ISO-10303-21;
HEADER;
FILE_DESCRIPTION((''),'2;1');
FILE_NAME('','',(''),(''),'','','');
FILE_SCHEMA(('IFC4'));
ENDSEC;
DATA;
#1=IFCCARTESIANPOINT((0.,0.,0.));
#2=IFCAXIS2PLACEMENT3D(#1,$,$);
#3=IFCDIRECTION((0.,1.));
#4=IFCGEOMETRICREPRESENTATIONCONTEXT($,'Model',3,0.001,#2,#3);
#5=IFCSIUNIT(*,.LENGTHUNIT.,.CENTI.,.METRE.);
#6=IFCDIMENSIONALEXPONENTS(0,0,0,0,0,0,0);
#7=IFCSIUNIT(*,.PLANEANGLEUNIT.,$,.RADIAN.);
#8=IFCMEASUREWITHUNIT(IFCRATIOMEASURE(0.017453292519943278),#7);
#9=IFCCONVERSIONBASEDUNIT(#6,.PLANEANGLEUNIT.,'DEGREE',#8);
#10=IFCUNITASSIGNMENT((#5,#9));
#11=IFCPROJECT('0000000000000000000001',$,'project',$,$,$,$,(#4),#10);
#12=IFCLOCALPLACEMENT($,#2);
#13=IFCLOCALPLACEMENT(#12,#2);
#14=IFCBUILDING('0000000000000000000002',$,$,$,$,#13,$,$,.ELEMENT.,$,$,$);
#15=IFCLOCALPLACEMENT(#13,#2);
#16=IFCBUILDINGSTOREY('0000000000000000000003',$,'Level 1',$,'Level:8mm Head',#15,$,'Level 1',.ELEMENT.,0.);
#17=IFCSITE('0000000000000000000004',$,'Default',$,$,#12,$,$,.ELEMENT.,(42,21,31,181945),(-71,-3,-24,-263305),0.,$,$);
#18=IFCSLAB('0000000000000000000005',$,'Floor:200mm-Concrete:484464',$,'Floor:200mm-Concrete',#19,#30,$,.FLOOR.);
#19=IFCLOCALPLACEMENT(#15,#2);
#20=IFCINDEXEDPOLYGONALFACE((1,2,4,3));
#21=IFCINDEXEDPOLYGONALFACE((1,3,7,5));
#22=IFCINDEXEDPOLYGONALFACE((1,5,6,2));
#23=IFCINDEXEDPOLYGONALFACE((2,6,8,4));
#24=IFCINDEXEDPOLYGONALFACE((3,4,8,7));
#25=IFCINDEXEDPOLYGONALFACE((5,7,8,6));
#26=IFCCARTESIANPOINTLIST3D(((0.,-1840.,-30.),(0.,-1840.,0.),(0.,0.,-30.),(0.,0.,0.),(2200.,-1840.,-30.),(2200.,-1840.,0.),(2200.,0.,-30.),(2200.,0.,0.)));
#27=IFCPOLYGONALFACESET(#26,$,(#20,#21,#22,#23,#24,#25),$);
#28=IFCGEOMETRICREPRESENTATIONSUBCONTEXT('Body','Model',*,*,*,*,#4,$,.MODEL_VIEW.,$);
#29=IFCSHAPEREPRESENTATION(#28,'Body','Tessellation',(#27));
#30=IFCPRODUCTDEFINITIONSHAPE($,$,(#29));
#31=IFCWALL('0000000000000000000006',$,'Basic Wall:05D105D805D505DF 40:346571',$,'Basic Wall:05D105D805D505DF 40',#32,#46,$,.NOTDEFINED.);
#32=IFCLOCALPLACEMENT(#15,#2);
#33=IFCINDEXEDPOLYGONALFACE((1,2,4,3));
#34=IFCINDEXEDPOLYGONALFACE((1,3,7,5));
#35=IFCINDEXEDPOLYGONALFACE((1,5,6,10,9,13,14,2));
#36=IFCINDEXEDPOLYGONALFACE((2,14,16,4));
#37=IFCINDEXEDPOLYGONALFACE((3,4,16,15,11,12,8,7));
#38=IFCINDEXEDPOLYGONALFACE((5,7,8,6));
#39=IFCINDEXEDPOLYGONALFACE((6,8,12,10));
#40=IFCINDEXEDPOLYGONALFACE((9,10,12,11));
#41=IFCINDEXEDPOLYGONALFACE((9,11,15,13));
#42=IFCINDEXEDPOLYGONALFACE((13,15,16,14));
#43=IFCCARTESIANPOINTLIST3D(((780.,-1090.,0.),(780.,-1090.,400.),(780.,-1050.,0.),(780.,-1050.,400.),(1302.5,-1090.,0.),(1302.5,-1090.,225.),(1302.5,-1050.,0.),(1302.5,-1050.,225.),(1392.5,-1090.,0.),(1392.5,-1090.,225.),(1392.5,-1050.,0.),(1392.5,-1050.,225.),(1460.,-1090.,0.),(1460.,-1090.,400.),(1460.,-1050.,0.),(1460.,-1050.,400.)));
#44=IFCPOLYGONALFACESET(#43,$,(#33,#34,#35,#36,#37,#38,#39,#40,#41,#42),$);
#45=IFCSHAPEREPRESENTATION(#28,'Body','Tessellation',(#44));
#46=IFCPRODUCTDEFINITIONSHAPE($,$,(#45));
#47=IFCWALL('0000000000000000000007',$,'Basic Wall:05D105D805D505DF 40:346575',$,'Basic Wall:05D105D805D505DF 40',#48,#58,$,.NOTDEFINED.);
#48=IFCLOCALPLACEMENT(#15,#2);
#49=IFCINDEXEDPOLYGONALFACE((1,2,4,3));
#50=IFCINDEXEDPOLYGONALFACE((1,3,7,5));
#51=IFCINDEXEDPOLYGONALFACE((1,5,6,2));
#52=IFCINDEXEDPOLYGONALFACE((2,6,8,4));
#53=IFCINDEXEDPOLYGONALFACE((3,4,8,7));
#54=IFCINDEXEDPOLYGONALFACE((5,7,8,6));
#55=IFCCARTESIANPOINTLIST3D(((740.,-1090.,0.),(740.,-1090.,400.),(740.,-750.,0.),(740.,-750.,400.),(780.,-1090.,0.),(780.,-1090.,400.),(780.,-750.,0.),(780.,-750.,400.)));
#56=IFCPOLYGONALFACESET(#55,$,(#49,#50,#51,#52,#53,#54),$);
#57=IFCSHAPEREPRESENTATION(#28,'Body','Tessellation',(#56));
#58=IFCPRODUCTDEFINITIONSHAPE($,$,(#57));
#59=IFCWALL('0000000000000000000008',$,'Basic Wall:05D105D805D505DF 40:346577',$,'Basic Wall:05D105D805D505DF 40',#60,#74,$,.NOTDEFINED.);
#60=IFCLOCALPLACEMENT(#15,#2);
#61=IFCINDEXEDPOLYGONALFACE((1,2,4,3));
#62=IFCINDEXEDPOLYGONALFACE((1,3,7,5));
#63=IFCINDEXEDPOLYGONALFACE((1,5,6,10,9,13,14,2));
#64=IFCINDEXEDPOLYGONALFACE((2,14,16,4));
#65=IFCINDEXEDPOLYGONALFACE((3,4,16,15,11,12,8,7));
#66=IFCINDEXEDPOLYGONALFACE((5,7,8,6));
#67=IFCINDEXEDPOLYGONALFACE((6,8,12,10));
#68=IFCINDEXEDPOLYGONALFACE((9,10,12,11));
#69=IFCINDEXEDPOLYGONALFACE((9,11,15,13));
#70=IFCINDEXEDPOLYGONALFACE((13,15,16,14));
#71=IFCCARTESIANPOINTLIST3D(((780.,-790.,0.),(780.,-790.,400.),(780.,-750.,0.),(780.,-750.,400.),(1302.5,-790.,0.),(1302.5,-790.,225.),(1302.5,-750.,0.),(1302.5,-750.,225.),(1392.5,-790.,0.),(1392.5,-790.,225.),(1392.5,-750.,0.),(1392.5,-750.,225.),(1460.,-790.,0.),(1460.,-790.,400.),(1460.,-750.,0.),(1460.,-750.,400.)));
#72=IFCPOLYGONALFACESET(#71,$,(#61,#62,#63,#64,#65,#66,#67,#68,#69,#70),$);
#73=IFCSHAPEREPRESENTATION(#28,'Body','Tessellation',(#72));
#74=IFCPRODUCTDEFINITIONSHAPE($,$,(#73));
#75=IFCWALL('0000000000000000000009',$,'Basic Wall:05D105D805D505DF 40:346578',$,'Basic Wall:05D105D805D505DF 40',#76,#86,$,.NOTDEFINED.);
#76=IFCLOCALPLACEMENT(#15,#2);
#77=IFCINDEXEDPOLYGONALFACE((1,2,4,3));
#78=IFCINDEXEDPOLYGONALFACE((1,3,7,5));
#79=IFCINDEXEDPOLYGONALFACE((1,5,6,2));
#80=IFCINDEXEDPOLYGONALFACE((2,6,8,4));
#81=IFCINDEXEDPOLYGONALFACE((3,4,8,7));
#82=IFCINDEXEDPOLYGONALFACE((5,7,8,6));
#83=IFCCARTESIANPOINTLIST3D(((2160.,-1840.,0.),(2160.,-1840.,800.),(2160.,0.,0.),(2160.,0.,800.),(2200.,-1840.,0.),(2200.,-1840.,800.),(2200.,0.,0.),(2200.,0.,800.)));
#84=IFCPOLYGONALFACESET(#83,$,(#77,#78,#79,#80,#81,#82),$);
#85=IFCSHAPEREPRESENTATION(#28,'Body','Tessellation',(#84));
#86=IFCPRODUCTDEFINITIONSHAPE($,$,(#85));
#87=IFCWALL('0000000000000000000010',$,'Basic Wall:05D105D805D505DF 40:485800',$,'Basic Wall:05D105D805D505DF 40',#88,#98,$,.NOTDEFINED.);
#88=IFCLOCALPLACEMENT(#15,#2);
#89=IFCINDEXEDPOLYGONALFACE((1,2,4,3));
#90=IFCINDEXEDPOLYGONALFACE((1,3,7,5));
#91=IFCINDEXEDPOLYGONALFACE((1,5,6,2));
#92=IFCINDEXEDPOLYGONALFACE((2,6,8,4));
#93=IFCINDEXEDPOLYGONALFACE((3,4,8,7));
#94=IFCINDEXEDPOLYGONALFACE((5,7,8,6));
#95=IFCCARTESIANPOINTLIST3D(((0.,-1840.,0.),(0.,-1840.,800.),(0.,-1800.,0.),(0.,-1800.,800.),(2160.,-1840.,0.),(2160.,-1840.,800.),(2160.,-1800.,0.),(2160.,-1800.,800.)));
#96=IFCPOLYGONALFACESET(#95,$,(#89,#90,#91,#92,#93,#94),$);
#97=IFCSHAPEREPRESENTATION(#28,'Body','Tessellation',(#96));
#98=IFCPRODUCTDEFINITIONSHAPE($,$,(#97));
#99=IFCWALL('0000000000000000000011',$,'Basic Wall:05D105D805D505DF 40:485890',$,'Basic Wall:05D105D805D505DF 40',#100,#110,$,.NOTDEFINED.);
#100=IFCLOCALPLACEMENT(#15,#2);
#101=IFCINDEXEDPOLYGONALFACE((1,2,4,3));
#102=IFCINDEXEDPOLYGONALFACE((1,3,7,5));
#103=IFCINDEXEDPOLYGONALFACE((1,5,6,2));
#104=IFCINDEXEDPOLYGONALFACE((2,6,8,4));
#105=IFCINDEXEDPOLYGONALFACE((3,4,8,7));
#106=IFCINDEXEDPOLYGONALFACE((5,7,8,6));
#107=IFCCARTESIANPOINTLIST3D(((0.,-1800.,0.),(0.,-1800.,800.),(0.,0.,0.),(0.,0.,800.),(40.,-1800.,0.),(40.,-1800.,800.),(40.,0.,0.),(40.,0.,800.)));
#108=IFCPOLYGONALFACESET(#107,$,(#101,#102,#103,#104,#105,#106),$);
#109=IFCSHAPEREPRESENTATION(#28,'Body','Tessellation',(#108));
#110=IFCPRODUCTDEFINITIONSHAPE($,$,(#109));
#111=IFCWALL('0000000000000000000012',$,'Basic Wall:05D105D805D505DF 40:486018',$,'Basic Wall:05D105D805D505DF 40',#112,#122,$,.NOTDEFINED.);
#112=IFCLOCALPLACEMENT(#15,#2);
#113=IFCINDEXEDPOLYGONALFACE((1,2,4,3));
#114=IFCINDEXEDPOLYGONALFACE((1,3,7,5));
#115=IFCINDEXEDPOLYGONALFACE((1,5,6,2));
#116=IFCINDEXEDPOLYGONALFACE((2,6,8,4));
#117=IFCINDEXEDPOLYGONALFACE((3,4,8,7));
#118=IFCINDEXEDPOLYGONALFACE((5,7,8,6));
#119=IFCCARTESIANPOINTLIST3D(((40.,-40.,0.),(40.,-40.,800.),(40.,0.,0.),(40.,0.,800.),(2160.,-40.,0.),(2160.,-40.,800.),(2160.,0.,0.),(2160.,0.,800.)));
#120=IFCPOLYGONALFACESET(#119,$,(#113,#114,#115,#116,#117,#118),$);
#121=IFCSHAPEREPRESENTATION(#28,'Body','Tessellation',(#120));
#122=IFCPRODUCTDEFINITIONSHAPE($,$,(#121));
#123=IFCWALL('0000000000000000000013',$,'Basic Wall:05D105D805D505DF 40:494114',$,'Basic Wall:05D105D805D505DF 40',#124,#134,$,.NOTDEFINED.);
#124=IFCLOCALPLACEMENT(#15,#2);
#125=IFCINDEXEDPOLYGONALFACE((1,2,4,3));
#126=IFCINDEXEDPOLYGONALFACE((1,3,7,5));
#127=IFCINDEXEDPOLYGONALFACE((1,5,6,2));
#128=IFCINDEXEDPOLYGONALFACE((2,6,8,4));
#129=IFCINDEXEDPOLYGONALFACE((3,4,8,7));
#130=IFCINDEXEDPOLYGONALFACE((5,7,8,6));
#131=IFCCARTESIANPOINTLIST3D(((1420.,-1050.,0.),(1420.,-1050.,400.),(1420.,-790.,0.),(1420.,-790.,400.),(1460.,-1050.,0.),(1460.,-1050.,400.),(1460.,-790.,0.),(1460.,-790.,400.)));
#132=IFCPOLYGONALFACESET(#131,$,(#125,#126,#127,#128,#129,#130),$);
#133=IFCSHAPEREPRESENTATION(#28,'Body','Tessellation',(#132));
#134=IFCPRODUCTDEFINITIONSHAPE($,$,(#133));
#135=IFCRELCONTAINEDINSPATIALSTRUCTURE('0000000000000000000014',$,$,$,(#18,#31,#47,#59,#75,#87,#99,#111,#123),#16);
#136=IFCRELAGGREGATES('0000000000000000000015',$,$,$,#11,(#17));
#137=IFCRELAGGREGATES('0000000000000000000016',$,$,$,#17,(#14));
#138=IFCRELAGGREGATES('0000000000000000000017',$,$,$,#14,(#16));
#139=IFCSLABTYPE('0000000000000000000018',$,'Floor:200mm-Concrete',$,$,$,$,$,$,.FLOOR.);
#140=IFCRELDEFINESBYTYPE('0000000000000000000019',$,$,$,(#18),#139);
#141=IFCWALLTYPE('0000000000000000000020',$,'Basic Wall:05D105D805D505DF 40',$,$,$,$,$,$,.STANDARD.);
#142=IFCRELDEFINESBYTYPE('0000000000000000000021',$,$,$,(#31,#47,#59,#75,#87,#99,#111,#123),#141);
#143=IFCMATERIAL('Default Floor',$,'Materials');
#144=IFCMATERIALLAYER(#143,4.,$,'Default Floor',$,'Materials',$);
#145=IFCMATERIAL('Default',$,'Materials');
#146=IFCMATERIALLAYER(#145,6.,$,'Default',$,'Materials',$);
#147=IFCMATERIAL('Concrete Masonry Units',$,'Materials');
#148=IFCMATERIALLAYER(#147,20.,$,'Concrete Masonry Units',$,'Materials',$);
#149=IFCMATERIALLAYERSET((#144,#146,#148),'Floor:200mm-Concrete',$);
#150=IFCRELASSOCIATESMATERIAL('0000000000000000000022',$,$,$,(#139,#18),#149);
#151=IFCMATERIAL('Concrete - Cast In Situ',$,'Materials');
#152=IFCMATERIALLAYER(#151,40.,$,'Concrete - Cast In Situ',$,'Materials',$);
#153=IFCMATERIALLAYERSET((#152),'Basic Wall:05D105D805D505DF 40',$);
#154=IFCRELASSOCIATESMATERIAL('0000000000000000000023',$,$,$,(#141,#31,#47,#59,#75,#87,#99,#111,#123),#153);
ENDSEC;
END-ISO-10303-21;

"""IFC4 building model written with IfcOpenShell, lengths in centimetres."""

from ifc_helpers import new_model, entity, si_unit, converted_unit, direction, frame, frame_2d, origin, origin_2d_with_axis, place, context, subcontext, project, spatial, rectangle, circle, extrude, material, layer, layer_set, layer_usage, type_object, element, save


model = new_model("IFC4")

# Units and contexts
model_context = context("Model", 3, precision=0.001, world=origin(), true_north=direction((0.0, 1.0)))
body_context = subcontext(model_context, "Body", "Model", "MODEL_VIEW")
ifc_project = project(units=[si_unit("LENGTHUNIT", "METRE", prefix="CENTI"), converted_unit("PLANEANGLEUNIT", "DEGREE", entity("IfcRatioMeasure", 0.017453292519943278), si_unit("PLANEANGLEUNIT", "RADIAN"), dimensions=[0, 0, 0, 0, 0, 0, 0])], contexts=[model_context])

# Site, building, storey
site_placement = place(None, origin())
site = spatial("IfcSite", under=ifc_project, at=site_placement, Name="Default", CompositionType="ELEMENT", RefLatitude=(42, 21, 31, 181945), RefLongitude=(-71, -3, -24, -263305), RefElevation=0.0)
building_placement = place(site_placement, origin())
building = spatial("IfcBuilding", under=site, at=building_placement, CompositionType="ELEMENT")
storey_placement = place(building_placement, origin())
storey = spatial("IfcBuildingStorey", under=building, at=storey_placement, Name="Level 1", ObjectType="Level:8mm Head", LongName="Level 1", CompositionType="ELEMENT", Elevation=0.0)

# Slab
ifc_material_1 = material(Name="Default Floor", Category="Materials")
ifc_layer_1 = layer(ifc_material_1, 4.0, Name="Default Floor", Category="Materials")
ifc_material_2 = material(Name="Default", Category="Materials")
ifc_layer_2 = layer(ifc_material_2, 6.0, Name="Default", Category="Materials")
ifc_material_3 = material(Name="Concrete Masonry Units", Category="Materials")
ifc_layer_3 = layer(ifc_material_3, 20.0, Name="Concrete Masonry Units", Category="Materials")
ifc_layer_set_1 = layer_set([ifc_layer_1, ifc_layer_2, ifc_layer_3], Name="Floor:200mm-Concrete")
ifc_layer_usage_1 = layer_usage(ifc_layer_set_1, "AXIS3", "POSITIVE", 0.0)
slab_type = type_object("IfcSlabType", Name="Floor:200mm-Concrete", PredefinedType="FLOOR", material=ifc_layer_set_1)
slab_placement = place(storey_placement, origin())
element("IfcSlab", 1, at=slab_placement, inside=storey, type_object=slab_type, material=ifc_layer_usage_1, Name="Floor:200mm-Concrete:484464", ObjectType="Floor:200mm-Concrete", PredefinedType="FLOOR", context=body_context, shape_type="SweptSolid", body=[
    extrude(rectangle(XDim=1840.0, YDim=2200.0, at=frame_2d((0.0, 0.0), x_axis=(1.0, 0.0))), frame((1100.0, -920.0, 0.0), z_axis=(0.0, 0.0, -1.0), x_axis=(0.0, 1.0, 0.0)), (0.0, 0.0, 1.0), 30.0),
])

# Wall, openings
ifc_material_4 = material(Name="Concrete - Cast In Situ", Category="Materials")
ifc_layer_4 = layer(ifc_material_4, 40.0, Name="Concrete - Cast In Situ", Category="Materials")
ifc_layer_set_2 = layer_set([ifc_layer_4], Name="Basic Wall:05D105D805D505DF 40")
ifc_layer_usage_2 = layer_usage(ifc_layer_set_2, "AXIS2", "POSITIVE", -20.0)
wall_type_1 = type_object("IfcWallType", Name="Basic Wall:05D105D805D505DF 40", PredefinedType="STANDARD", material=ifc_layer_set_2)
wall_1_placement = place(storey_placement, frame((780.0, -1070.0, 0.0)))
wall_1 = element("IfcWall", 2, at=wall_1_placement, inside=storey, type_object=wall_type_1, material=ifc_layer_usage_2, Name="Basic Wall:05D105D805D505DF 40:346571", ObjectType="Basic Wall:05D105D805D505DF 40", PredefinedType="NOTDEFINED", context=body_context, shape_type="SweptSolid", body=[
    extrude(rectangle(XDim=680.0, YDim=40.0, at=frame_2d((340.0, 0.0), x_axis=(-1.0, 0.0))), origin(), (0.0, 0.0, 1.0), 400.0),
])
opening_1_placement = place(wall_1_placement, origin())
element("IfcOpeningElement", 3, at=opening_1_placement, cuts=wall_1, PredefinedType="OPENING", context=body_context, shape_type="SweptSolid", body=[
    extrude(circle(Radius=4.0, at=origin_2d_with_axis()), frame((567.52, 20.0, 323.98), z_axis=(0.0, -1.0, 0.0), x_axis=(-1.0, 0.0, 0.0)), (0.0, 0.0, 1.0), 40.0),
])
opening_2_placement = place(wall_1_placement, frame((522.5, -20.0, 0.0)))
element("IfcOpeningElement", 4, at=opening_2_placement, cuts=wall_1, PredefinedType="OPENING", context=body_context, shape_type="SweptSolid", body=[
    extrude(rectangle(XDim=225.0, YDim=90.0, at=frame_2d((112.5, 45.0), x_axis=(-1.0, 0.0))), frame((0.0, 0.0, 0.0), z_axis=(0.0, 1.0, 0.0), x_axis=(0.0, 0.0, 1.0)), (0.0, 0.0, 1.0), 40.0),
])
opening_3_placement = place(wall_1_placement, frame((522.5, -20.0, 400.0)))
element("IfcOpeningElement", 5, at=opening_3_placement, cuts=wall_1, PredefinedType="OPENING", context=body_context, shape_type="SweptSolid", body=[
    extrude(rectangle(XDim=225.0, YDim=90.0, at=frame_2d((112.5, 45.0), x_axis=(-1.0, 0.0))), frame((0.0, 0.0, 0.0), z_axis=(0.0, 1.0, 0.0), x_axis=(0.0, 0.0, 1.0)), (0.0, 0.0, 1.0), 40.0),
])

# Wall
ifc_layer_usage_3 = layer_usage(ifc_layer_set_2, "AXIS2", "NEGATIVE", 20.0)
wall_2_placement = place(storey_placement, frame((760.0, -1090.0, 0.0), z_axis=(0.0, 0.0, 1.0), x_axis=(0.0, 1.0, 0.0)))
element("IfcWall", 6, at=wall_2_placement, inside=storey, type_object=wall_type_1, material=ifc_layer_usage_3, Name="Basic Wall:05D105D805D505DF 40:346575", ObjectType="Basic Wall:05D105D805D505DF 40", PredefinedType="NOTDEFINED", context=body_context, shape_type="SweptSolid", body=[
    extrude(rectangle(XDim=340.0, YDim=40.0, at=frame_2d((170.0, 0.0), x_axis=(-1.0, 0.0))), origin(), (0.0, 0.0, 1.0), 400.0),
])

# Wall, openings
ifc_layer_usage_4 = layer_usage(ifc_layer_set_2, "AXIS2", "NEGATIVE", 20.0)
wall_3_placement = place(storey_placement, frame((780.0, -770.0, 0.0)))
wall_3 = element("IfcWall", 7, at=wall_3_placement, inside=storey, type_object=wall_type_1, material=ifc_layer_usage_4, Name="Basic Wall:05D105D805D505DF 40:346577", ObjectType="Basic Wall:05D105D805D505DF 40", PredefinedType="NOTDEFINED", context=body_context, shape_type="SweptSolid", body=[
    extrude(rectangle(XDim=680.0, YDim=40.0, at=frame_2d((340.0, 0.0), x_axis=(-1.0, 0.0))), origin(), (0.0, 0.0, 1.0), 400.0),
])
opening_4_placement = place(wall_3_placement, frame((612.5, 20.0, 0.0)))
element("IfcOpeningElement", 8, at=opening_4_placement, cuts=wall_3, PredefinedType="OPENING", context=body_context, shape_type="SweptSolid", body=[
    extrude(rectangle(XDim=225.0, YDim=90.0, at=frame_2d((112.5, 45.0), x_axis=(-1.0, 0.0))), frame((0.0, 0.0, 0.0), z_axis=(0.0, -1.0, 0.0), x_axis=(0.0, 0.0, 1.0)), (0.0, 0.0, 1.0), 40.0),
])
opening_5_placement = place(wall_3_placement, frame((612.5, 20.0, 400.0)))
element("IfcOpeningElement", 9, at=opening_5_placement, cuts=wall_3, PredefinedType="OPENING", context=body_context, shape_type="SweptSolid", body=[
    extrude(rectangle(XDim=225.0, YDim=90.0, at=frame_2d((112.5, 45.0), x_axis=(-1.0, 0.0))), frame((0.0, 0.0, 0.0), z_axis=(0.0, -1.0, 0.0), x_axis=(0.0, 0.0, 1.0)), (0.0, 0.0, 1.0), 40.0),
])

# Walls
ifc_layer_usage_5 = layer_usage(ifc_layer_set_2, "AXIS2", "POSITIVE", -20.0)
wall_4_placement = place(storey_placement, frame((2180.0, 0.0, 0.0), z_axis=(0.0, 0.0, 1.0), x_axis=(0.0, -1.0, 0.0)))
element("IfcWall", 10, at=wall_4_placement, inside=storey, type_object=wall_type_1, material=ifc_layer_usage_5, Name="Basic Wall:05D105D805D505DF 40:346578", ObjectType="Basic Wall:05D105D805D505DF 40", PredefinedType="NOTDEFINED", context=body_context, shape_type="SweptSolid", body=[
    extrude(rectangle(XDim=1840.0, YDim=40.0, at=frame_2d((920.0, 0.0), x_axis=(-1.0, 0.0))), origin(), (0.0, 0.0, 1.0), 800.0),
])
ifc_layer_usage_6 = layer_usage(ifc_layer_set_2, "AXIS2", "NEGATIVE", 20.0)
wall_5_placement = place(storey_placement, frame((2160.0, -1820.0, 0.0), z_axis=(0.0, 0.0, 1.0), x_axis=(-1.0, 0.0, 0.0)))
element("IfcWall", 11, at=wall_5_placement, inside=storey, type_object=wall_type_1, material=ifc_layer_usage_6, Name="Basic Wall:05D105D805D505DF 40:485800", ObjectType="Basic Wall:05D105D805D505DF 40", PredefinedType="NOTDEFINED", context=body_context, shape_type="SweptSolid", body=[
    extrude(rectangle(XDim=2160.0, YDim=40.0, at=frame_2d((1080.0, 0.0), x_axis=(-1.0, 0.0))), origin(), (0.0, 0.0, 1.0), 800.0),
])
ifc_layer_usage_7 = layer_usage(ifc_layer_set_2, "AXIS2", "NEGATIVE", 20.0)
wall_6_placement = place(storey_placement, frame((20.0, -1800.0, 0.0), z_axis=(0.0, 0.0, 1.0), x_axis=(0.0, 1.0, 0.0)))
element("IfcWall", 12, at=wall_6_placement, inside=storey, type_object=wall_type_1, material=ifc_layer_usage_7, Name="Basic Wall:05D105D805D505DF 40:485890", ObjectType="Basic Wall:05D105D805D505DF 40", PredefinedType="NOTDEFINED", context=body_context, shape_type="SweptSolid", body=[
    extrude(rectangle(XDim=1800.0, YDim=40.0, at=frame_2d((900.0, 0.0), x_axis=(-1.0, 0.0))), origin(), (0.0, 0.0, 1.0), 800.0),
])
ifc_layer_usage_8 = layer_usage(ifc_layer_set_2, "AXIS2", "NEGATIVE", 20.0)
wall_7_placement = place(storey_placement, frame((40.0, -20.0, 0.0)))
element("IfcWall", 13, at=wall_7_placement, inside=storey, type_object=wall_type_1, material=ifc_layer_usage_8, Name="Basic Wall:05D105D805D505DF 40:486018", ObjectType="Basic Wall:05D105D805D505DF 40", PredefinedType="NOTDEFINED", context=body_context, shape_type="SweptSolid", body=[
    extrude(rectangle(XDim=2120.0, YDim=40.0, at=frame_2d((1060.0, 0.0), x_axis=(-1.0, 0.0))), origin(), (0.0, 0.0, 1.0), 800.0),
])
ifc_layer_usage_9 = layer_usage(ifc_layer_set_2, "AXIS2", "NEGATIVE", 20.0)
wall_8_placement = place(storey_placement, frame((1440.0, -1050.0, 0.0), z_axis=(0.0, 0.0, 1.0), x_axis=(0.0, 1.0, 0.0)))
element("IfcWall", 14, at=wall_8_placement, inside=storey, type_object=wall_type_1, material=ifc_layer_usage_9, Name="Basic Wall:05D105D805D505DF 40:494114", ObjectType="Basic Wall:05D105D805D505DF 40", PredefinedType="NOTDEFINED", context=body_context, shape_type="SweptSolid", body=[
    extrude(rectangle(XDim=260.0, YDim=40.0, at=frame_2d((130.0, 0.0), x_axis=(-1.0, 0.0))), origin(), (0.0, 0.0, 1.0), 400.0),
])

save(model, "model.ifc")
